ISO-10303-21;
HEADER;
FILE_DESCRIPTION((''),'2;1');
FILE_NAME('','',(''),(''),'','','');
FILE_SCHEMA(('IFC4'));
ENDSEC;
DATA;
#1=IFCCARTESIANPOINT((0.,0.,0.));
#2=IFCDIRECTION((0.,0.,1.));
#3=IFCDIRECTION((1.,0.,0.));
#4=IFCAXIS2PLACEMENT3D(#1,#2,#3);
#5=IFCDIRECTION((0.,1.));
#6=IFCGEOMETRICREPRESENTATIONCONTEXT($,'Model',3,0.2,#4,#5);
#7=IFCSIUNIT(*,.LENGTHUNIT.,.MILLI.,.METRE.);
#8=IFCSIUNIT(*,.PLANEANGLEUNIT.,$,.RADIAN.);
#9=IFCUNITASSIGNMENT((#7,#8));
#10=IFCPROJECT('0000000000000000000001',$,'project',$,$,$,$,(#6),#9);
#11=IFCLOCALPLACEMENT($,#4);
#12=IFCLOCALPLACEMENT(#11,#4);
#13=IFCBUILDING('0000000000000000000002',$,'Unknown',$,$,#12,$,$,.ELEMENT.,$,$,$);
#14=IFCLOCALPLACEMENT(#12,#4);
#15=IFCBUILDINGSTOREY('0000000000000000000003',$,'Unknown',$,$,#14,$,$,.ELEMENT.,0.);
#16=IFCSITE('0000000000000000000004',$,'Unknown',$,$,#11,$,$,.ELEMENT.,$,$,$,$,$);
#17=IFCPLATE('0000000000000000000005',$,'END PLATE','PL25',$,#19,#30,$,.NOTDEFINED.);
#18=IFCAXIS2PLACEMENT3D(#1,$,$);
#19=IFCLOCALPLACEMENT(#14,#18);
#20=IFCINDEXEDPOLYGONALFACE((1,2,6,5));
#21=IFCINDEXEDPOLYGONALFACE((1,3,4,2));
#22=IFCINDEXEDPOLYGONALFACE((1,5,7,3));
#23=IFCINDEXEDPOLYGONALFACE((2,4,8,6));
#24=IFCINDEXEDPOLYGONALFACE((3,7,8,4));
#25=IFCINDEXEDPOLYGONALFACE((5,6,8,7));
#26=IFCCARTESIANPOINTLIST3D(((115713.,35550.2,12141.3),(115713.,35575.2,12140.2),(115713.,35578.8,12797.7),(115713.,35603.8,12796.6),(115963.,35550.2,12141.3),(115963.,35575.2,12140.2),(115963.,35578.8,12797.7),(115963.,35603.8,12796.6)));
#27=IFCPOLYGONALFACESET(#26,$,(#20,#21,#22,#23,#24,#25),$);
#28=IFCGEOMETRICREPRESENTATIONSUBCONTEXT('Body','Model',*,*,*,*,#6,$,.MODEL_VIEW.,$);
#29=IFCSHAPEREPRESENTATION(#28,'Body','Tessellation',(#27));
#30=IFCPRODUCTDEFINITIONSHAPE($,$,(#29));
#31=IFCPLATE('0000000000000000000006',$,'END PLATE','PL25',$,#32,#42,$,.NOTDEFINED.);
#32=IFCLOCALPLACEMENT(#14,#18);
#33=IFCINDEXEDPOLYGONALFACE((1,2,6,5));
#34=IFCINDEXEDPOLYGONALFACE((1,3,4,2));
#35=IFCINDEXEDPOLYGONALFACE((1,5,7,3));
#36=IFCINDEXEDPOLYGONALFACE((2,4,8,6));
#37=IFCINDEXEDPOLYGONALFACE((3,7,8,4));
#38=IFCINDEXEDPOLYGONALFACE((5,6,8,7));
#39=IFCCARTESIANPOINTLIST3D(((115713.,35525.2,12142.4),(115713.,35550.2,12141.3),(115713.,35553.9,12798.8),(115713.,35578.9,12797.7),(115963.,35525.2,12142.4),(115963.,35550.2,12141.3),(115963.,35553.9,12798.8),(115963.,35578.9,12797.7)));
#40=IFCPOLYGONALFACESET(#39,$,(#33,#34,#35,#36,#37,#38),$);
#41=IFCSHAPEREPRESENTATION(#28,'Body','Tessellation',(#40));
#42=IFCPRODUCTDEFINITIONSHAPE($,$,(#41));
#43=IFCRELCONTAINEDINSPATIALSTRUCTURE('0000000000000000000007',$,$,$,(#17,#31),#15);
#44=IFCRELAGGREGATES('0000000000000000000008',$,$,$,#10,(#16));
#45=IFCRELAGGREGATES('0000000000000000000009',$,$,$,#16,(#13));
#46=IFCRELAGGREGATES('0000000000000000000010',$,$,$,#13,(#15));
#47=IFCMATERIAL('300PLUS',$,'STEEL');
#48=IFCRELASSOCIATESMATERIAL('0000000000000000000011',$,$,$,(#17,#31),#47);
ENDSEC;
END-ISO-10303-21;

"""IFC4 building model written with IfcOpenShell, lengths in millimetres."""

from ifc_helpers import new_model, si_unit, direction, frame, origin_with_axes, place, context, subcontext, project, spatial, line, indexed_curve, outline, extrude, material, element, save


model = new_model("IFC4")

# Units and contexts
model_context = context("Model", 3, precision=0.2, world=origin_with_axes(), true_north=direction((0.0, 1.0)))
body_context = subcontext(model_context, "Body", "Model", "MODEL_VIEW")
ifc_project = project(units=[si_unit("LENGTHUNIT", "METRE", prefix="MILLI"), si_unit("PLANEANGLEUNIT", "RADIAN")], contexts=[model_context])

# Site, building, storey
site_placement = place(None, origin_with_axes())
site = spatial("IfcSite", under=ifc_project, at=site_placement, Name="Unknown", CompositionType="ELEMENT")
building_placement = place(site_placement, origin_with_axes())
building = spatial("IfcBuilding", under=site, at=building_placement, Name="Unknown", CompositionType="ELEMENT")
storey_placement = place(building_placement, origin_with_axes())
storey = spatial("IfcBuildingStorey", under=building, at=storey_placement, Name="Unknown", CompositionType="ELEMENT", Elevation=0.0)

# Plates
ifc_material_1 = material(Name="300PLUS", Category="STEEL")
plate_1_placement = place(storey_placement, frame((115963.0, 35591.3, 12797.1), z_axis=(0.0, -0.999052, 0.04353), x_axis=(-1.0, 0.0, 0.0)))
element("IfcPlate", 1, at=plate_1_placement, inside=storey, material=ifc_material_1, Name="END PLATE", Description="PL25", PredefinedType="NOTDEFINED", context=body_context, shape_type="SolidModel", body=[
    extrude(outline(indexed_curve([(0.0, 0.0), (250.0, 0.0), (250.0, 657.0), (0.0, 657.0)], segments=[line(1, 2, 3, 4, 1)])), frame((0.0, 0.0, 12.5), z_axis=(0.0, 0.0, 1.0), x_axis=(1.0, 0.0, 0.0)), (0.0, 0.0, -1.0), 25.0),
])
plate_2_placement = place(storey_placement, frame((115963.0, 35566.4, 12798.2), z_axis=(0.0, -0.999046, 0.043682), x_axis=(-1.0, 0.0, 0.0)))
element("IfcPlate", 2, at=plate_2_placement, inside=storey, material=ifc_material_1, Name="END PLATE", Description="PL25", PredefinedType="NOTDEFINED", context=body_context, shape_type="SolidModel", body=[
    extrude(outline(indexed_curve([(0.0, 0.0), (250.0, 0.0), (250.0, 657.0), (0.0, 657.0)], segments=[line(1, 2, 3, 4, 1)])), frame((0.0, 0.0, 12.5), z_axis=(0.0, 0.0, 1.0), x_axis=(1.0, 0.0, 0.0)), (0.0, 0.0, -1.0), 25.0),
])

save(model, "model.ifc")
